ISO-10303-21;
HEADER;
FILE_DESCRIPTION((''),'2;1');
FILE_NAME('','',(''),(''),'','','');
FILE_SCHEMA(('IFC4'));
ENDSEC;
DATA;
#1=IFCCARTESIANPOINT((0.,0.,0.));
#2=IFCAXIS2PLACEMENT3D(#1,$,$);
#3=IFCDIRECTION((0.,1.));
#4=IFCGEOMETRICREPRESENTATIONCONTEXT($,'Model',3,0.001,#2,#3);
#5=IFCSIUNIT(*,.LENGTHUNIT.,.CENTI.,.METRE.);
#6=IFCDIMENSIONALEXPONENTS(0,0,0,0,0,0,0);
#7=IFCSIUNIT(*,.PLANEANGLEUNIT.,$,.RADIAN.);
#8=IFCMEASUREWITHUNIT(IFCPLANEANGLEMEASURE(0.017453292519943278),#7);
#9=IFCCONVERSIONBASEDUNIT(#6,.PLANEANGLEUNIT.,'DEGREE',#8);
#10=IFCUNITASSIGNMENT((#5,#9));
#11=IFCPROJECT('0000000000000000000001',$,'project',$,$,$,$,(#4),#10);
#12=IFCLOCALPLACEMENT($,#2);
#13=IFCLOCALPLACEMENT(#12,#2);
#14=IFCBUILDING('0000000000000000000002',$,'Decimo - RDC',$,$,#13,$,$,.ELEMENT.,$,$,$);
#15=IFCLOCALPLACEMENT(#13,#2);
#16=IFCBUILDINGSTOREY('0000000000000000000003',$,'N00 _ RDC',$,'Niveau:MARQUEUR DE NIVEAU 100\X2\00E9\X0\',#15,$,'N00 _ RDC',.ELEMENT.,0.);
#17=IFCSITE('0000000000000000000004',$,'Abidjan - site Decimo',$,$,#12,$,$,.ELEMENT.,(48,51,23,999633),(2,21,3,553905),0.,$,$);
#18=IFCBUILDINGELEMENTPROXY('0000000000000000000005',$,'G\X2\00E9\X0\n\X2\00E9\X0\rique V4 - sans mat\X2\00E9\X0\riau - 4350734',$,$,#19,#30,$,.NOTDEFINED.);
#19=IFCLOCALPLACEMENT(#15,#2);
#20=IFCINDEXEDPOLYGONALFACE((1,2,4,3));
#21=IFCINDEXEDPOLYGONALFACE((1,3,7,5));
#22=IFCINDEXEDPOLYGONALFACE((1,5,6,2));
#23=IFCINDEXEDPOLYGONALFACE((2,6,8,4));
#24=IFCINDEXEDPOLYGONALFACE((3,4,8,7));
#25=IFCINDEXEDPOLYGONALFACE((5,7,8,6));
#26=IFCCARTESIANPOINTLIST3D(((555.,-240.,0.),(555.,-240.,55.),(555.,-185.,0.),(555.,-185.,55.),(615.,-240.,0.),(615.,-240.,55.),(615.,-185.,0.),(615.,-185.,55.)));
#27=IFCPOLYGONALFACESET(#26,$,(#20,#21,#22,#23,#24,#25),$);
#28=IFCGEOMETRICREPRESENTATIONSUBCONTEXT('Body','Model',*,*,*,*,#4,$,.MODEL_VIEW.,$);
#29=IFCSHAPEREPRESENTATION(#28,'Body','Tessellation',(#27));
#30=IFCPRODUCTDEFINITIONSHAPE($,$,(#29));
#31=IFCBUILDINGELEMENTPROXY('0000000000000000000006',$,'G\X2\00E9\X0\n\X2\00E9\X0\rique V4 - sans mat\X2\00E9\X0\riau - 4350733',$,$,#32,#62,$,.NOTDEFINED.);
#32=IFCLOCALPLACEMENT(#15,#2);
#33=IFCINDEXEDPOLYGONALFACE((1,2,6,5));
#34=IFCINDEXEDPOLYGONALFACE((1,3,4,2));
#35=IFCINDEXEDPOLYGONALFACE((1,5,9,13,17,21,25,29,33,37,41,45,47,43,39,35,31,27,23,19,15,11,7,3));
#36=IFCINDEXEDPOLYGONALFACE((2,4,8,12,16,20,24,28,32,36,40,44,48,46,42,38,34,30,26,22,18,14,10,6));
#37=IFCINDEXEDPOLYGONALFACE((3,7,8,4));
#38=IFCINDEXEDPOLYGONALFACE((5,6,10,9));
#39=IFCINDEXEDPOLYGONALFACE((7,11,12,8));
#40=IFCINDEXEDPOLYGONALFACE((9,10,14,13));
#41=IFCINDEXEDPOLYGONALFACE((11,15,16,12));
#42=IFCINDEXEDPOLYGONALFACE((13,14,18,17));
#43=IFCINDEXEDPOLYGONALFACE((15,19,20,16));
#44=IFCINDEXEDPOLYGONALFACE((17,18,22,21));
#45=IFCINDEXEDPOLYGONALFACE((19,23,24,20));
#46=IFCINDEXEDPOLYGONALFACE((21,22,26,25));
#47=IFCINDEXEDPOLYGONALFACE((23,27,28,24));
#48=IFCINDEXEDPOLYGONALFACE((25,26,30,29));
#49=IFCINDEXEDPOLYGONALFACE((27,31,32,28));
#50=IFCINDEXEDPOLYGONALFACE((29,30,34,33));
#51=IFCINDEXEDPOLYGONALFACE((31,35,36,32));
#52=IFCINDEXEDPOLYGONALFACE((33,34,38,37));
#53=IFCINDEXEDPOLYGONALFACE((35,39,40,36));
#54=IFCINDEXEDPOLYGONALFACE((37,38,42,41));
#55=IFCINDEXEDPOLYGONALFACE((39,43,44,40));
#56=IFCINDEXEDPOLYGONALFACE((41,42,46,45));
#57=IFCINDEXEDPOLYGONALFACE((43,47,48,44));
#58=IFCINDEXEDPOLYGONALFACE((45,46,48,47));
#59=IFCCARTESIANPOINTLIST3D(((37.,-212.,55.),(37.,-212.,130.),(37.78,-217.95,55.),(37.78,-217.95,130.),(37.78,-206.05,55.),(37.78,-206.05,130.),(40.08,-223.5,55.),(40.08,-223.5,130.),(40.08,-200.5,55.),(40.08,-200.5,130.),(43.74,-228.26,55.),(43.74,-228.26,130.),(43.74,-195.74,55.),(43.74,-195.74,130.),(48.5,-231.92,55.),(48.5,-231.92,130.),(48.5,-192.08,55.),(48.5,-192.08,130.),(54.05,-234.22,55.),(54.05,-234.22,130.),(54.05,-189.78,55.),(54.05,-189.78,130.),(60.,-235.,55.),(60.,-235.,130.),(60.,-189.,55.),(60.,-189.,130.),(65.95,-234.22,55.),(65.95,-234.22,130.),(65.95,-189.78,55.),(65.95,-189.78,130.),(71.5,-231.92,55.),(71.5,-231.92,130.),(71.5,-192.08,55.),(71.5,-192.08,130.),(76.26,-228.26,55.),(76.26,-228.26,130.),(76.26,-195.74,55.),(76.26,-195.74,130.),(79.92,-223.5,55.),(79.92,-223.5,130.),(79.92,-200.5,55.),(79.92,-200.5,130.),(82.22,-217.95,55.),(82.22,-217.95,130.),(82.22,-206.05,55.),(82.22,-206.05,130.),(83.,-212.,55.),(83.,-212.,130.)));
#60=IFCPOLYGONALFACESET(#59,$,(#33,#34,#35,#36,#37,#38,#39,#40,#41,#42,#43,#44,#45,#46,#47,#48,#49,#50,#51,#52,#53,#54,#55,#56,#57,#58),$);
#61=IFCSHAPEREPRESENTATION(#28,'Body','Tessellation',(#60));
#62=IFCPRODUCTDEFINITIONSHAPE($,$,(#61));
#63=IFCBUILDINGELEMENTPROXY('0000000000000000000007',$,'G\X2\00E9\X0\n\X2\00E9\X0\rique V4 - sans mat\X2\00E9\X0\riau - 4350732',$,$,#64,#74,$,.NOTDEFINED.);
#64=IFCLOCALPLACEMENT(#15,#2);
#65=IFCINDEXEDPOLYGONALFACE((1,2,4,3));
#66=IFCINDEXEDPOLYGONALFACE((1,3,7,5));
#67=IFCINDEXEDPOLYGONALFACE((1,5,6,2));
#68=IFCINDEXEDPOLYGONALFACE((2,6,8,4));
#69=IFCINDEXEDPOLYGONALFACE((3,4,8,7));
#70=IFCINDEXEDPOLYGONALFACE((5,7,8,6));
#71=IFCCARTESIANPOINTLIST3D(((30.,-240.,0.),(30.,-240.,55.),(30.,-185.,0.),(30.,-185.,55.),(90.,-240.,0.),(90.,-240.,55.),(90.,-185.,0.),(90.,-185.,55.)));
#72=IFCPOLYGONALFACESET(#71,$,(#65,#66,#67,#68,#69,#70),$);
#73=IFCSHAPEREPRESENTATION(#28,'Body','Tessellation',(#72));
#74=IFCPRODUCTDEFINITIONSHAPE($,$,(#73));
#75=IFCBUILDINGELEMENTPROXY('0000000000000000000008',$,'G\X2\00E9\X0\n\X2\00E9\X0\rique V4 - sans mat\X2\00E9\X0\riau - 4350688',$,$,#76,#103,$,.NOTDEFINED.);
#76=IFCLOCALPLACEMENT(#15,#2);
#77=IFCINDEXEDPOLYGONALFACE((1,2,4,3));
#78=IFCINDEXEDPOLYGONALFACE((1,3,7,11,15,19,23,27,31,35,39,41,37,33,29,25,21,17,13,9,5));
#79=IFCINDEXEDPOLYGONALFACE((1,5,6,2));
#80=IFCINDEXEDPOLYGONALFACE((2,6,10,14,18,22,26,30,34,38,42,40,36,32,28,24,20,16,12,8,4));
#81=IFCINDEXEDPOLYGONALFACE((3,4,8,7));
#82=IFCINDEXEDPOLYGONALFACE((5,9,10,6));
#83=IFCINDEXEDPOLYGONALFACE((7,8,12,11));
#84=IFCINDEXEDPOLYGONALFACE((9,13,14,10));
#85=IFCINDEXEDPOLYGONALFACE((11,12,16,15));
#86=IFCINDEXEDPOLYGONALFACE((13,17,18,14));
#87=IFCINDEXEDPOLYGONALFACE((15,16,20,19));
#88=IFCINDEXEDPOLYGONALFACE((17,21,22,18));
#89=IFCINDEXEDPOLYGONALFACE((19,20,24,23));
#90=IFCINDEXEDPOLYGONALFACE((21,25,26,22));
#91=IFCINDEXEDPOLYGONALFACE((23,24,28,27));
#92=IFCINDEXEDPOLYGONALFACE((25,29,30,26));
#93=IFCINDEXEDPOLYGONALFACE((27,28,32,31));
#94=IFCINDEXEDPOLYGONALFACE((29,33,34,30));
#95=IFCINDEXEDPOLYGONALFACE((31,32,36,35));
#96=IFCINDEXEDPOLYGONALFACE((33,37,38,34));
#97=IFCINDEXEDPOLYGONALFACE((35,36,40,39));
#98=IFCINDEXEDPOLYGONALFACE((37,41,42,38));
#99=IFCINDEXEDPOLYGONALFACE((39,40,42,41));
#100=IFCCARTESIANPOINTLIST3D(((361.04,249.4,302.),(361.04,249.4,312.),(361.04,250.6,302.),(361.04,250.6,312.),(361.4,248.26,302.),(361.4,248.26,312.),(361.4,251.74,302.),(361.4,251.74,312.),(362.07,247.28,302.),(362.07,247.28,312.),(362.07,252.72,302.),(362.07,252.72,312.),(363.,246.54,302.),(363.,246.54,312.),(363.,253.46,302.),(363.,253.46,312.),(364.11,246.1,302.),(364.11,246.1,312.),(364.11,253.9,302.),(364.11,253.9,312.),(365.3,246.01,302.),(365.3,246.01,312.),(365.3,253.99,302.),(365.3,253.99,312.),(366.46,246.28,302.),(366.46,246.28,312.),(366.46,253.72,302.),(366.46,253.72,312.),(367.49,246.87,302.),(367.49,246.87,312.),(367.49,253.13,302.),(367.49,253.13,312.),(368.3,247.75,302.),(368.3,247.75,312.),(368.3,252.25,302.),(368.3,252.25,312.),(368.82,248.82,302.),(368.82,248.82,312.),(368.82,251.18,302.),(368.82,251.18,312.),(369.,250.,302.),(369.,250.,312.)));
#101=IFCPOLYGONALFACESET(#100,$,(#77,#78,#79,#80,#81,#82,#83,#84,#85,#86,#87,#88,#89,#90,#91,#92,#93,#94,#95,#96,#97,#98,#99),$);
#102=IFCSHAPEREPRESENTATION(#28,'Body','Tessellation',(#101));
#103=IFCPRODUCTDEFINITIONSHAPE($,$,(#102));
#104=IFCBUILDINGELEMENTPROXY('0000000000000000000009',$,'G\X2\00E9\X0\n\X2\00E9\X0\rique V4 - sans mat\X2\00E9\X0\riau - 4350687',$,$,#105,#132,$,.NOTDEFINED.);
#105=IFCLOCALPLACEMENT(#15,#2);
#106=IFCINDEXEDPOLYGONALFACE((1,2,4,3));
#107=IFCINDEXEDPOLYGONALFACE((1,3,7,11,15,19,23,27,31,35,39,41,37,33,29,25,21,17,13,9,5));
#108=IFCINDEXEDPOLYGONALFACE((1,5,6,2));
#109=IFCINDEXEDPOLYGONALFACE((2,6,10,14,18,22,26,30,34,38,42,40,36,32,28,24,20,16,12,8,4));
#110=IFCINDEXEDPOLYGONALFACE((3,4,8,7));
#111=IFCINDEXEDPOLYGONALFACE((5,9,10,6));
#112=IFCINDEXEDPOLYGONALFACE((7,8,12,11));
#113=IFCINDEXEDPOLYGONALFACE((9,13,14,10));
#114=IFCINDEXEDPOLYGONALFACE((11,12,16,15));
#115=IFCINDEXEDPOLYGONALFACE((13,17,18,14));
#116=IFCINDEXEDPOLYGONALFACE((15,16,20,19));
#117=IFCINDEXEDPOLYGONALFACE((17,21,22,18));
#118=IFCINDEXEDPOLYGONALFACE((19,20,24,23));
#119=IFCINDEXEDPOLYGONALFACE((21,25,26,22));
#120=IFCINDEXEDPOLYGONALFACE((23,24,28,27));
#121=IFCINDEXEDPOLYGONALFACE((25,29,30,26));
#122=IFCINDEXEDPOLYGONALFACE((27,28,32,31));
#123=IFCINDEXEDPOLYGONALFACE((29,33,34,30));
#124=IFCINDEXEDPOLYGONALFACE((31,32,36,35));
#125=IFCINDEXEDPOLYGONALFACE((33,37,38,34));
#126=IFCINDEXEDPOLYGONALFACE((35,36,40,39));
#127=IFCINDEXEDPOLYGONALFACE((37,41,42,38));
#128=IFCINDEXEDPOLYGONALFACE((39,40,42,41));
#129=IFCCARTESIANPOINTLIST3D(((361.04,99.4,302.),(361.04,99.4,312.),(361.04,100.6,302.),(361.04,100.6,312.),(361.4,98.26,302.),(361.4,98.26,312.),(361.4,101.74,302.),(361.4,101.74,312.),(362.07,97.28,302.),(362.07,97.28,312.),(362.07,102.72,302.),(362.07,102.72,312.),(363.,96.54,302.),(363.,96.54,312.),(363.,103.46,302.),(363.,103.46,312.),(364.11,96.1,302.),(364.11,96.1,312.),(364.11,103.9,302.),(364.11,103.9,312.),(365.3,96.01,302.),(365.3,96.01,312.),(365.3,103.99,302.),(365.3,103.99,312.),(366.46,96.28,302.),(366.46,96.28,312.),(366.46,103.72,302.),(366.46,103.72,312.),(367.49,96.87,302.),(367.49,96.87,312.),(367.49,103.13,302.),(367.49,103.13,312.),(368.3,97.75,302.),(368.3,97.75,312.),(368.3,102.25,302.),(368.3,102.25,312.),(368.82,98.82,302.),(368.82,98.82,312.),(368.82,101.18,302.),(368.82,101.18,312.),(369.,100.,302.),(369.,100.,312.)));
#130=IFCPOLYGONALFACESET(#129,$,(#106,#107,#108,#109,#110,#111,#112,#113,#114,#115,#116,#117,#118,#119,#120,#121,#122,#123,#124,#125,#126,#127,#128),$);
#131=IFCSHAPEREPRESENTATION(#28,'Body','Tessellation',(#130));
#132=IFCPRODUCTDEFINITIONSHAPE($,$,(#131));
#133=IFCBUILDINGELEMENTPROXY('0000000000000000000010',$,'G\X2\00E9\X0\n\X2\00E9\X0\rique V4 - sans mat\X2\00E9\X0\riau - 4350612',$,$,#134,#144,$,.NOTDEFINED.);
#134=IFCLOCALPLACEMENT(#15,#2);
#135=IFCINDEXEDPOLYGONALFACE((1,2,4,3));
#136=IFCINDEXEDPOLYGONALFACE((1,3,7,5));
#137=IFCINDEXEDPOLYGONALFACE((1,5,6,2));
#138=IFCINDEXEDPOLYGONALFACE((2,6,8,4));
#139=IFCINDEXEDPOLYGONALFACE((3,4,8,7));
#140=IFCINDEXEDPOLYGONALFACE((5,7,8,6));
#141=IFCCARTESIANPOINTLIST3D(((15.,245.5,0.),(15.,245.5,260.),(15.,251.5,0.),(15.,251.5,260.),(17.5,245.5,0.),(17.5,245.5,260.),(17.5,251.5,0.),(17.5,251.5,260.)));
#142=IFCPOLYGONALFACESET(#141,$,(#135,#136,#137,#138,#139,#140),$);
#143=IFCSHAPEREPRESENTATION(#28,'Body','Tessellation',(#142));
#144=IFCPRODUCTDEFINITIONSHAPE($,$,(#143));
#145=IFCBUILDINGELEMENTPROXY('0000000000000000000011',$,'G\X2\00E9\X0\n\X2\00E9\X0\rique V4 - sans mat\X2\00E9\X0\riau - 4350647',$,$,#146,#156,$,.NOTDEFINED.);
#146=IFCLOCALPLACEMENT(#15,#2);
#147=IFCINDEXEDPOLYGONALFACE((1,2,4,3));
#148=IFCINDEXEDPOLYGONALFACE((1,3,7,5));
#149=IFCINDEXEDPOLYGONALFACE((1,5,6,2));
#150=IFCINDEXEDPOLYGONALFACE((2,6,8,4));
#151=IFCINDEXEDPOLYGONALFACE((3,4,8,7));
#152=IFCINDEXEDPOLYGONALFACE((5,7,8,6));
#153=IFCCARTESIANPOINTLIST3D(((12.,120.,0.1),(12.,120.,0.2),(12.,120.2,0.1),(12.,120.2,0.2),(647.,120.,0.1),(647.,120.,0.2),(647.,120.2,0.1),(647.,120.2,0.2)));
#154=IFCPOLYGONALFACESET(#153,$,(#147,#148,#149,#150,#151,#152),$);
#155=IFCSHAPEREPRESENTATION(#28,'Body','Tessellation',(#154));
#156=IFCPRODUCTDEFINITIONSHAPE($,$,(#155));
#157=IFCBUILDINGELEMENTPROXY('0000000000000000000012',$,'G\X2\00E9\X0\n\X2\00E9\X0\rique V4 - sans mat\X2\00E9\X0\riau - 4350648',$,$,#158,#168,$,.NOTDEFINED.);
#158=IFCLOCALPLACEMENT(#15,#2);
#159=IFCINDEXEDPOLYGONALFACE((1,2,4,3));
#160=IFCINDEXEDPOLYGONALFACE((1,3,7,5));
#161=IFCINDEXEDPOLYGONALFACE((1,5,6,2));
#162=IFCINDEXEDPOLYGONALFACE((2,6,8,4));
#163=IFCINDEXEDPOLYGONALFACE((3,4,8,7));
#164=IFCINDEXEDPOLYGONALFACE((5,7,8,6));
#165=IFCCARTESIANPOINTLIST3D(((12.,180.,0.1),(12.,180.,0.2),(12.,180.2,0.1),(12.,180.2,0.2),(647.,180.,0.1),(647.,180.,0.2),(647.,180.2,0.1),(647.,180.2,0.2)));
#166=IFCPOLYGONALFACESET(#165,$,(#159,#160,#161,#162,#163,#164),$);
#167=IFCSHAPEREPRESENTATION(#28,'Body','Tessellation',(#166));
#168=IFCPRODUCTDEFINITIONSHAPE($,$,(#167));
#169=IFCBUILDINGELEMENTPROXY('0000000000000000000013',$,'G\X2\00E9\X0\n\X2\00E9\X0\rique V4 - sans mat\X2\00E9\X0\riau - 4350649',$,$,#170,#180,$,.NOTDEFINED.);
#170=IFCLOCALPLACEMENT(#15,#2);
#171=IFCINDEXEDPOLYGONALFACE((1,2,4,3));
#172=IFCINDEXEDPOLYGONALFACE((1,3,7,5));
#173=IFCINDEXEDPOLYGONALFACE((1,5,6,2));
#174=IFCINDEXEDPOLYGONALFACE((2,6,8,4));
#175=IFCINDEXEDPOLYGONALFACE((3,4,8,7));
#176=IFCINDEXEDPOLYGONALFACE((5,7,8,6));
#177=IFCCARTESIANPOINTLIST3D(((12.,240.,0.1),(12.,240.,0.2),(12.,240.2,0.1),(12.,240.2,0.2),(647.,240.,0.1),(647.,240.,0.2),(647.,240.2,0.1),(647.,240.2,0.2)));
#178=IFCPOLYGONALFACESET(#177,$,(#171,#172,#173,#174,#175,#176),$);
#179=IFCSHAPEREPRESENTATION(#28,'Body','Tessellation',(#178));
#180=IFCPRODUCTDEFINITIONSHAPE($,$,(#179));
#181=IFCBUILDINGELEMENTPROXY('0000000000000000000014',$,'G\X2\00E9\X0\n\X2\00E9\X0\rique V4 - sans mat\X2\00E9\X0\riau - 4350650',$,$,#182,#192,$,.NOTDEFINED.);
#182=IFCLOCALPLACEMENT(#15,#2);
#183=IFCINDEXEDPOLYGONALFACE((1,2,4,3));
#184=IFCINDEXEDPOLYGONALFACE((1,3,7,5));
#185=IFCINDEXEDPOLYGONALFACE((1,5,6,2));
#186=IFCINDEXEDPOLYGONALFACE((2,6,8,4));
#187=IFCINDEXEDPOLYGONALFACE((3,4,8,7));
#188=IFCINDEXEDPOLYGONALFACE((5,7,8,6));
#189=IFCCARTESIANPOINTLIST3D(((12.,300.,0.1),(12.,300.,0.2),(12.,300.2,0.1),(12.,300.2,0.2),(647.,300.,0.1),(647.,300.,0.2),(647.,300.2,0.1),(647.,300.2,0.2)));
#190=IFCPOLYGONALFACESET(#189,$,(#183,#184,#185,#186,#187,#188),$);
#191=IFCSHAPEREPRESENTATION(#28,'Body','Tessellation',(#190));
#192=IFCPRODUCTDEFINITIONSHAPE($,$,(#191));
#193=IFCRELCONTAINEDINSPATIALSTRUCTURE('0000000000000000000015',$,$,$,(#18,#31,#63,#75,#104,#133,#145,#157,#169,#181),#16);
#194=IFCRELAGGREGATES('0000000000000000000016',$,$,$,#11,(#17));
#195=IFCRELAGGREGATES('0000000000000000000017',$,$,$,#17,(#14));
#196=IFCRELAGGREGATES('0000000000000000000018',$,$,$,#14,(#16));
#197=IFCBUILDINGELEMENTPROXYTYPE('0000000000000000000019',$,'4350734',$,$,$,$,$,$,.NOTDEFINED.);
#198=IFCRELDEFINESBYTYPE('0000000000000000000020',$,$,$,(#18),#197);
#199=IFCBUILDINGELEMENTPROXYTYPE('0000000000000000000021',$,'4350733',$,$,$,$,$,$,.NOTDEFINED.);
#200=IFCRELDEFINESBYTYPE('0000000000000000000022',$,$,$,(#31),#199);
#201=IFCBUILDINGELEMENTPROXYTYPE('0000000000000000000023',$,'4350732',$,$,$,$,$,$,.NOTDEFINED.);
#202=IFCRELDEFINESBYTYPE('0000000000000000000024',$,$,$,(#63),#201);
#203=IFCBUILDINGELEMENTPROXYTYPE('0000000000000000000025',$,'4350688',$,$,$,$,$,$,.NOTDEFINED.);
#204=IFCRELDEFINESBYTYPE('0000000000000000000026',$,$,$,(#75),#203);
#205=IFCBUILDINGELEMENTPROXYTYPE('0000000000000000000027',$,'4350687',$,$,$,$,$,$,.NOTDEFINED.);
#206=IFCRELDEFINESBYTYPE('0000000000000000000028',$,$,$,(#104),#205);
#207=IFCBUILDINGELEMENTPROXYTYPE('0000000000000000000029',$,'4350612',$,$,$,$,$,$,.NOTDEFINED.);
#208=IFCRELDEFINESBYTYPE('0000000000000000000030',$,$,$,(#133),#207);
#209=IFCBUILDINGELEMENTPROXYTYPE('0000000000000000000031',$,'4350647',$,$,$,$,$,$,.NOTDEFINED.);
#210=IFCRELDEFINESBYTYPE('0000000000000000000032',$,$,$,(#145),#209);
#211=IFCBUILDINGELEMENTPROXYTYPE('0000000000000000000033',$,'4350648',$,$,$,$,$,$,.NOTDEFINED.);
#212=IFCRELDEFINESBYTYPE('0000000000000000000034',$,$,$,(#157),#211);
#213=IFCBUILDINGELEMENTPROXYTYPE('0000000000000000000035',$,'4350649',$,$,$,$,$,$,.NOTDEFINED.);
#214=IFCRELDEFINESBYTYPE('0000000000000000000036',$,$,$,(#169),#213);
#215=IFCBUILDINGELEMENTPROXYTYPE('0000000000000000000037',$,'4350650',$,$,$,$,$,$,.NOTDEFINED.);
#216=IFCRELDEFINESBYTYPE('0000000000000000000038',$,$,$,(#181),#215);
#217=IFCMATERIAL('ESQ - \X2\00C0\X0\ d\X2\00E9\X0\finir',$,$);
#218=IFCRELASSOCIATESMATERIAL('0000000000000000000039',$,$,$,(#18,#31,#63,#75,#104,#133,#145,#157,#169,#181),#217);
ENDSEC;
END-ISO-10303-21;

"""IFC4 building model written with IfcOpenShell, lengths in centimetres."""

from ifc_helpers import new_model, entity, si_unit, converted_unit, direction, frame, frame_2d, origin, origin_2d_with_axis, place, context, subcontext, project, spatial, rectangle, circle, extrude, material, type_object, element, save


model = new_model("IFC4")

# Units and contexts
model_context = context("Model", 3, precision=0.001, world=origin(), true_north=direction((0.0, 1.0)))
body_context = subcontext(model_context, "Body", "Model", "MODEL_VIEW")
ifc_project = project(units=[si_unit("LENGTHUNIT", "METRE", prefix="CENTI"), converted_unit("PLANEANGLEUNIT", "DEGREE", entity("IfcPlaneAngleMeasure", 0.017453292519943278), si_unit("PLANEANGLEUNIT", "RADIAN"), dimensions=[0, 0, 0, 0, 0, 0, 0])], contexts=[model_context])

# Site, building, storey
site_placement = place(None, origin())
site = spatial("IfcSite", under=ifc_project, at=site_placement, Name="Abidjan - site Decimo", CompositionType="ELEMENT", RefLatitude=(48, 51, 23, 999633), RefLongitude=(2, 21, 3, 553905), RefElevation=0.0)
building_placement = place(site_placement, origin())
building = spatial("IfcBuilding", under=site, at=building_placement, Name="Decimo - RDC", CompositionType="ELEMENT")
storey_placement = place(building_placement, origin())
storey = spatial("IfcBuildingStorey", under=building, at=storey_placement, Name="N00 _ RDC", ObjectType="Niveau:MARQUEUR DE NIVEAU 100é", LongName="N00 _ RDC", CompositionType="ELEMENT", Elevation=0.0)

# Building element proxies
ifc_material_1 = material(Name="ESQ - À définir")
building_element_proxy_type_1 = type_object("IfcBuildingElementProxyType", Name="4350734", PredefinedType="NOTDEFINED")
proxy_1_placement = place(storey_placement, origin())
element("IfcBuildingElementProxy", 1, at=proxy_1_placement, inside=storey, type_object=building_element_proxy_type_1, material=ifc_material_1, Name="Générique V4 - sans matériau - 4350734", PredefinedType="NOTDEFINED", context=body_context, shape_type="SweptSolid", body=[
    extrude(rectangle(XDim=60.0, YDim=55.0, at=origin_2d_with_axis()), frame((585.0, -212.5, 0.0)), (0.0, 0.0, 1.0), 55.0),
])
building_element_proxy_type_2 = type_object("IfcBuildingElementProxyType", Name="4350733", PredefinedType="NOTDEFINED")
proxy_2_placement = place(storey_placement, origin())
element("IfcBuildingElementProxy", 2, at=proxy_2_placement, inside=storey, type_object=building_element_proxy_type_2, material=ifc_material_1, Name="Générique V4 - sans matériau - 4350733", PredefinedType="NOTDEFINED", context=body_context, shape_type="SweptSolid", body=[
    extrude(circle(Radius=23.0, at=origin_2d_with_axis()), frame((60.0, -212.0, 55.0)), (0.0, 0.0, 1.0), 75.0),
])
building_element_proxy_type_3 = type_object("IfcBuildingElementProxyType", Name="4350732", PredefinedType="NOTDEFINED")
proxy_3_placement = place(storey_placement, origin())
element("IfcBuildingElementProxy", 3, at=proxy_3_placement, inside=storey, type_object=building_element_proxy_type_3, material=ifc_material_1, Name="Générique V4 - sans matériau - 4350732", PredefinedType="NOTDEFINED", context=body_context, shape_type="SweptSolid", body=[
    extrude(rectangle(XDim=60.0, YDim=55.0, at=frame_2d((0.0, 0.0), x_axis=(1.0, 0.0))), frame((60.0, -212.5, 0.0)), (0.0, 0.0, 1.0), 55.0),
])
building_element_proxy_type_4 = type_object("IfcBuildingElementProxyType", Name="4350688", PredefinedType="NOTDEFINED")
proxy_4_placement = place(storey_placement, origin())
element("IfcBuildingElementProxy", 4, at=proxy_4_placement, inside=storey, type_object=building_element_proxy_type_4, material=ifc_material_1, Name="Générique V4 - sans matériau - 4350688", PredefinedType="NOTDEFINED", context=body_context, shape_type="SweptSolid", body=[
    extrude(circle(Radius=4.0, at=origin_2d_with_axis()), frame((365.0, 250.0, 302.0)), (0.0, 0.0, 1.0), 10.0),
])
building_element_proxy_type_5 = type_object("IfcBuildingElementProxyType", Name="4350687", PredefinedType="NOTDEFINED")
proxy_5_placement = place(storey_placement, origin())
element("IfcBuildingElementProxy", 5, at=proxy_5_placement, inside=storey, type_object=building_element_proxy_type_5, material=ifc_material_1, Name="Générique V4 - sans matériau - 4350687", PredefinedType="NOTDEFINED", context=body_context, shape_type="SweptSolid", body=[
    extrude(circle(Radius=4.0, at=origin_2d_with_axis()), frame((365.0, 100.0, 302.0)), (0.0, 0.0, 1.0), 10.0),
])
building_element_proxy_type_6 = type_object("IfcBuildingElementProxyType", Name="4350612", PredefinedType="NOTDEFINED")
proxy_6_placement = place(storey_placement, origin())
element("IfcBuildingElementProxy", 6, at=proxy_6_placement, inside=storey, type_object=building_element_proxy_type_6, material=ifc_material_1, Name="Générique V4 - sans matériau - 4350612", PredefinedType="NOTDEFINED", context=body_context, shape_type="SweptSolid", body=[
    extrude(rectangle(XDim=2.5, YDim=6.0, at=frame_2d((0.0, 0.0), x_axis=(1.0, 0.0))), frame((16.25, 248.5, 0.0)), (0.0, 0.0, 1.0), 260.0),
])
building_element_proxy_type_7 = type_object("IfcBuildingElementProxyType", Name="4350647", PredefinedType="NOTDEFINED")
proxy_7_placement = place(storey_placement, origin())
element("IfcBuildingElementProxy", 7, at=proxy_7_placement, inside=storey, type_object=building_element_proxy_type_7, material=ifc_material_1, Name="Générique V4 - sans matériau - 4350647", PredefinedType="NOTDEFINED", context=body_context, shape_type="SweptSolid", body=[
    extrude(rectangle(XDim=635.0, YDim=0.2, at=frame_2d((0.0, 0.0), x_axis=(1.0, 0.0))), frame((329.5, 120.1, 0.1)), (0.0, 0.0, 1.0), 0.1),
])
building_element_proxy_type_8 = type_object("IfcBuildingElementProxyType", Name="4350648", PredefinedType="NOTDEFINED")
proxy_8_placement = place(storey_placement, origin())
element("IfcBuildingElementProxy", 8, at=proxy_8_placement, inside=storey, type_object=building_element_proxy_type_8, material=ifc_material_1, Name="Générique V4 - sans matériau - 4350648", PredefinedType="NOTDEFINED", context=body_context, shape_type="SweptSolid", body=[
    extrude(rectangle(XDim=635.0, YDim=0.2, at=frame_2d((0.0, 0.0), x_axis=(1.0, 0.0))), frame((329.5, 180.1, 0.1)), (0.0, 0.0, 1.0), 0.1),
])
building_element_proxy_type_9 = type_object("IfcBuildingElementProxyType", Name="4350649", PredefinedType="NOTDEFINED")
proxy_9_placement = place(storey_placement, origin())
element("IfcBuildingElementProxy", 9, at=proxy_9_placement, inside=storey, type_object=building_element_proxy_type_9, material=ifc_material_1, Name="Générique V4 - sans matériau - 4350649", PredefinedType="NOTDEFINED", context=body_context, shape_type="SweptSolid", body=[
    extrude(rectangle(XDim=635.0, YDim=0.2, at=frame_2d((0.0, 0.0), x_axis=(1.0, 0.0))), frame((329.5, 240.1, 0.1)), (0.0, 0.0, 1.0), 0.1),
])
building_element_proxy_type_10 = type_object("IfcBuildingElementProxyType", Name="4350650", PredefinedType="NOTDEFINED")
proxy_10_placement = place(storey_placement, origin())
element("IfcBuildingElementProxy", 10, at=proxy_10_placement, inside=storey, type_object=building_element_proxy_type_10, material=ifc_material_1, Name="Générique V4 - sans matériau - 4350650", PredefinedType="NOTDEFINED", context=body_context, shape_type="SweptSolid", body=[
    extrude(rectangle(XDim=635.0, YDim=0.2, at=frame_2d((0.0, 0.0), x_axis=(1.0, 0.0))), frame((329.5, 300.1, 0.1)), (0.0, 0.0, 1.0), 0.1),
])

save(model, "model.ifc")
